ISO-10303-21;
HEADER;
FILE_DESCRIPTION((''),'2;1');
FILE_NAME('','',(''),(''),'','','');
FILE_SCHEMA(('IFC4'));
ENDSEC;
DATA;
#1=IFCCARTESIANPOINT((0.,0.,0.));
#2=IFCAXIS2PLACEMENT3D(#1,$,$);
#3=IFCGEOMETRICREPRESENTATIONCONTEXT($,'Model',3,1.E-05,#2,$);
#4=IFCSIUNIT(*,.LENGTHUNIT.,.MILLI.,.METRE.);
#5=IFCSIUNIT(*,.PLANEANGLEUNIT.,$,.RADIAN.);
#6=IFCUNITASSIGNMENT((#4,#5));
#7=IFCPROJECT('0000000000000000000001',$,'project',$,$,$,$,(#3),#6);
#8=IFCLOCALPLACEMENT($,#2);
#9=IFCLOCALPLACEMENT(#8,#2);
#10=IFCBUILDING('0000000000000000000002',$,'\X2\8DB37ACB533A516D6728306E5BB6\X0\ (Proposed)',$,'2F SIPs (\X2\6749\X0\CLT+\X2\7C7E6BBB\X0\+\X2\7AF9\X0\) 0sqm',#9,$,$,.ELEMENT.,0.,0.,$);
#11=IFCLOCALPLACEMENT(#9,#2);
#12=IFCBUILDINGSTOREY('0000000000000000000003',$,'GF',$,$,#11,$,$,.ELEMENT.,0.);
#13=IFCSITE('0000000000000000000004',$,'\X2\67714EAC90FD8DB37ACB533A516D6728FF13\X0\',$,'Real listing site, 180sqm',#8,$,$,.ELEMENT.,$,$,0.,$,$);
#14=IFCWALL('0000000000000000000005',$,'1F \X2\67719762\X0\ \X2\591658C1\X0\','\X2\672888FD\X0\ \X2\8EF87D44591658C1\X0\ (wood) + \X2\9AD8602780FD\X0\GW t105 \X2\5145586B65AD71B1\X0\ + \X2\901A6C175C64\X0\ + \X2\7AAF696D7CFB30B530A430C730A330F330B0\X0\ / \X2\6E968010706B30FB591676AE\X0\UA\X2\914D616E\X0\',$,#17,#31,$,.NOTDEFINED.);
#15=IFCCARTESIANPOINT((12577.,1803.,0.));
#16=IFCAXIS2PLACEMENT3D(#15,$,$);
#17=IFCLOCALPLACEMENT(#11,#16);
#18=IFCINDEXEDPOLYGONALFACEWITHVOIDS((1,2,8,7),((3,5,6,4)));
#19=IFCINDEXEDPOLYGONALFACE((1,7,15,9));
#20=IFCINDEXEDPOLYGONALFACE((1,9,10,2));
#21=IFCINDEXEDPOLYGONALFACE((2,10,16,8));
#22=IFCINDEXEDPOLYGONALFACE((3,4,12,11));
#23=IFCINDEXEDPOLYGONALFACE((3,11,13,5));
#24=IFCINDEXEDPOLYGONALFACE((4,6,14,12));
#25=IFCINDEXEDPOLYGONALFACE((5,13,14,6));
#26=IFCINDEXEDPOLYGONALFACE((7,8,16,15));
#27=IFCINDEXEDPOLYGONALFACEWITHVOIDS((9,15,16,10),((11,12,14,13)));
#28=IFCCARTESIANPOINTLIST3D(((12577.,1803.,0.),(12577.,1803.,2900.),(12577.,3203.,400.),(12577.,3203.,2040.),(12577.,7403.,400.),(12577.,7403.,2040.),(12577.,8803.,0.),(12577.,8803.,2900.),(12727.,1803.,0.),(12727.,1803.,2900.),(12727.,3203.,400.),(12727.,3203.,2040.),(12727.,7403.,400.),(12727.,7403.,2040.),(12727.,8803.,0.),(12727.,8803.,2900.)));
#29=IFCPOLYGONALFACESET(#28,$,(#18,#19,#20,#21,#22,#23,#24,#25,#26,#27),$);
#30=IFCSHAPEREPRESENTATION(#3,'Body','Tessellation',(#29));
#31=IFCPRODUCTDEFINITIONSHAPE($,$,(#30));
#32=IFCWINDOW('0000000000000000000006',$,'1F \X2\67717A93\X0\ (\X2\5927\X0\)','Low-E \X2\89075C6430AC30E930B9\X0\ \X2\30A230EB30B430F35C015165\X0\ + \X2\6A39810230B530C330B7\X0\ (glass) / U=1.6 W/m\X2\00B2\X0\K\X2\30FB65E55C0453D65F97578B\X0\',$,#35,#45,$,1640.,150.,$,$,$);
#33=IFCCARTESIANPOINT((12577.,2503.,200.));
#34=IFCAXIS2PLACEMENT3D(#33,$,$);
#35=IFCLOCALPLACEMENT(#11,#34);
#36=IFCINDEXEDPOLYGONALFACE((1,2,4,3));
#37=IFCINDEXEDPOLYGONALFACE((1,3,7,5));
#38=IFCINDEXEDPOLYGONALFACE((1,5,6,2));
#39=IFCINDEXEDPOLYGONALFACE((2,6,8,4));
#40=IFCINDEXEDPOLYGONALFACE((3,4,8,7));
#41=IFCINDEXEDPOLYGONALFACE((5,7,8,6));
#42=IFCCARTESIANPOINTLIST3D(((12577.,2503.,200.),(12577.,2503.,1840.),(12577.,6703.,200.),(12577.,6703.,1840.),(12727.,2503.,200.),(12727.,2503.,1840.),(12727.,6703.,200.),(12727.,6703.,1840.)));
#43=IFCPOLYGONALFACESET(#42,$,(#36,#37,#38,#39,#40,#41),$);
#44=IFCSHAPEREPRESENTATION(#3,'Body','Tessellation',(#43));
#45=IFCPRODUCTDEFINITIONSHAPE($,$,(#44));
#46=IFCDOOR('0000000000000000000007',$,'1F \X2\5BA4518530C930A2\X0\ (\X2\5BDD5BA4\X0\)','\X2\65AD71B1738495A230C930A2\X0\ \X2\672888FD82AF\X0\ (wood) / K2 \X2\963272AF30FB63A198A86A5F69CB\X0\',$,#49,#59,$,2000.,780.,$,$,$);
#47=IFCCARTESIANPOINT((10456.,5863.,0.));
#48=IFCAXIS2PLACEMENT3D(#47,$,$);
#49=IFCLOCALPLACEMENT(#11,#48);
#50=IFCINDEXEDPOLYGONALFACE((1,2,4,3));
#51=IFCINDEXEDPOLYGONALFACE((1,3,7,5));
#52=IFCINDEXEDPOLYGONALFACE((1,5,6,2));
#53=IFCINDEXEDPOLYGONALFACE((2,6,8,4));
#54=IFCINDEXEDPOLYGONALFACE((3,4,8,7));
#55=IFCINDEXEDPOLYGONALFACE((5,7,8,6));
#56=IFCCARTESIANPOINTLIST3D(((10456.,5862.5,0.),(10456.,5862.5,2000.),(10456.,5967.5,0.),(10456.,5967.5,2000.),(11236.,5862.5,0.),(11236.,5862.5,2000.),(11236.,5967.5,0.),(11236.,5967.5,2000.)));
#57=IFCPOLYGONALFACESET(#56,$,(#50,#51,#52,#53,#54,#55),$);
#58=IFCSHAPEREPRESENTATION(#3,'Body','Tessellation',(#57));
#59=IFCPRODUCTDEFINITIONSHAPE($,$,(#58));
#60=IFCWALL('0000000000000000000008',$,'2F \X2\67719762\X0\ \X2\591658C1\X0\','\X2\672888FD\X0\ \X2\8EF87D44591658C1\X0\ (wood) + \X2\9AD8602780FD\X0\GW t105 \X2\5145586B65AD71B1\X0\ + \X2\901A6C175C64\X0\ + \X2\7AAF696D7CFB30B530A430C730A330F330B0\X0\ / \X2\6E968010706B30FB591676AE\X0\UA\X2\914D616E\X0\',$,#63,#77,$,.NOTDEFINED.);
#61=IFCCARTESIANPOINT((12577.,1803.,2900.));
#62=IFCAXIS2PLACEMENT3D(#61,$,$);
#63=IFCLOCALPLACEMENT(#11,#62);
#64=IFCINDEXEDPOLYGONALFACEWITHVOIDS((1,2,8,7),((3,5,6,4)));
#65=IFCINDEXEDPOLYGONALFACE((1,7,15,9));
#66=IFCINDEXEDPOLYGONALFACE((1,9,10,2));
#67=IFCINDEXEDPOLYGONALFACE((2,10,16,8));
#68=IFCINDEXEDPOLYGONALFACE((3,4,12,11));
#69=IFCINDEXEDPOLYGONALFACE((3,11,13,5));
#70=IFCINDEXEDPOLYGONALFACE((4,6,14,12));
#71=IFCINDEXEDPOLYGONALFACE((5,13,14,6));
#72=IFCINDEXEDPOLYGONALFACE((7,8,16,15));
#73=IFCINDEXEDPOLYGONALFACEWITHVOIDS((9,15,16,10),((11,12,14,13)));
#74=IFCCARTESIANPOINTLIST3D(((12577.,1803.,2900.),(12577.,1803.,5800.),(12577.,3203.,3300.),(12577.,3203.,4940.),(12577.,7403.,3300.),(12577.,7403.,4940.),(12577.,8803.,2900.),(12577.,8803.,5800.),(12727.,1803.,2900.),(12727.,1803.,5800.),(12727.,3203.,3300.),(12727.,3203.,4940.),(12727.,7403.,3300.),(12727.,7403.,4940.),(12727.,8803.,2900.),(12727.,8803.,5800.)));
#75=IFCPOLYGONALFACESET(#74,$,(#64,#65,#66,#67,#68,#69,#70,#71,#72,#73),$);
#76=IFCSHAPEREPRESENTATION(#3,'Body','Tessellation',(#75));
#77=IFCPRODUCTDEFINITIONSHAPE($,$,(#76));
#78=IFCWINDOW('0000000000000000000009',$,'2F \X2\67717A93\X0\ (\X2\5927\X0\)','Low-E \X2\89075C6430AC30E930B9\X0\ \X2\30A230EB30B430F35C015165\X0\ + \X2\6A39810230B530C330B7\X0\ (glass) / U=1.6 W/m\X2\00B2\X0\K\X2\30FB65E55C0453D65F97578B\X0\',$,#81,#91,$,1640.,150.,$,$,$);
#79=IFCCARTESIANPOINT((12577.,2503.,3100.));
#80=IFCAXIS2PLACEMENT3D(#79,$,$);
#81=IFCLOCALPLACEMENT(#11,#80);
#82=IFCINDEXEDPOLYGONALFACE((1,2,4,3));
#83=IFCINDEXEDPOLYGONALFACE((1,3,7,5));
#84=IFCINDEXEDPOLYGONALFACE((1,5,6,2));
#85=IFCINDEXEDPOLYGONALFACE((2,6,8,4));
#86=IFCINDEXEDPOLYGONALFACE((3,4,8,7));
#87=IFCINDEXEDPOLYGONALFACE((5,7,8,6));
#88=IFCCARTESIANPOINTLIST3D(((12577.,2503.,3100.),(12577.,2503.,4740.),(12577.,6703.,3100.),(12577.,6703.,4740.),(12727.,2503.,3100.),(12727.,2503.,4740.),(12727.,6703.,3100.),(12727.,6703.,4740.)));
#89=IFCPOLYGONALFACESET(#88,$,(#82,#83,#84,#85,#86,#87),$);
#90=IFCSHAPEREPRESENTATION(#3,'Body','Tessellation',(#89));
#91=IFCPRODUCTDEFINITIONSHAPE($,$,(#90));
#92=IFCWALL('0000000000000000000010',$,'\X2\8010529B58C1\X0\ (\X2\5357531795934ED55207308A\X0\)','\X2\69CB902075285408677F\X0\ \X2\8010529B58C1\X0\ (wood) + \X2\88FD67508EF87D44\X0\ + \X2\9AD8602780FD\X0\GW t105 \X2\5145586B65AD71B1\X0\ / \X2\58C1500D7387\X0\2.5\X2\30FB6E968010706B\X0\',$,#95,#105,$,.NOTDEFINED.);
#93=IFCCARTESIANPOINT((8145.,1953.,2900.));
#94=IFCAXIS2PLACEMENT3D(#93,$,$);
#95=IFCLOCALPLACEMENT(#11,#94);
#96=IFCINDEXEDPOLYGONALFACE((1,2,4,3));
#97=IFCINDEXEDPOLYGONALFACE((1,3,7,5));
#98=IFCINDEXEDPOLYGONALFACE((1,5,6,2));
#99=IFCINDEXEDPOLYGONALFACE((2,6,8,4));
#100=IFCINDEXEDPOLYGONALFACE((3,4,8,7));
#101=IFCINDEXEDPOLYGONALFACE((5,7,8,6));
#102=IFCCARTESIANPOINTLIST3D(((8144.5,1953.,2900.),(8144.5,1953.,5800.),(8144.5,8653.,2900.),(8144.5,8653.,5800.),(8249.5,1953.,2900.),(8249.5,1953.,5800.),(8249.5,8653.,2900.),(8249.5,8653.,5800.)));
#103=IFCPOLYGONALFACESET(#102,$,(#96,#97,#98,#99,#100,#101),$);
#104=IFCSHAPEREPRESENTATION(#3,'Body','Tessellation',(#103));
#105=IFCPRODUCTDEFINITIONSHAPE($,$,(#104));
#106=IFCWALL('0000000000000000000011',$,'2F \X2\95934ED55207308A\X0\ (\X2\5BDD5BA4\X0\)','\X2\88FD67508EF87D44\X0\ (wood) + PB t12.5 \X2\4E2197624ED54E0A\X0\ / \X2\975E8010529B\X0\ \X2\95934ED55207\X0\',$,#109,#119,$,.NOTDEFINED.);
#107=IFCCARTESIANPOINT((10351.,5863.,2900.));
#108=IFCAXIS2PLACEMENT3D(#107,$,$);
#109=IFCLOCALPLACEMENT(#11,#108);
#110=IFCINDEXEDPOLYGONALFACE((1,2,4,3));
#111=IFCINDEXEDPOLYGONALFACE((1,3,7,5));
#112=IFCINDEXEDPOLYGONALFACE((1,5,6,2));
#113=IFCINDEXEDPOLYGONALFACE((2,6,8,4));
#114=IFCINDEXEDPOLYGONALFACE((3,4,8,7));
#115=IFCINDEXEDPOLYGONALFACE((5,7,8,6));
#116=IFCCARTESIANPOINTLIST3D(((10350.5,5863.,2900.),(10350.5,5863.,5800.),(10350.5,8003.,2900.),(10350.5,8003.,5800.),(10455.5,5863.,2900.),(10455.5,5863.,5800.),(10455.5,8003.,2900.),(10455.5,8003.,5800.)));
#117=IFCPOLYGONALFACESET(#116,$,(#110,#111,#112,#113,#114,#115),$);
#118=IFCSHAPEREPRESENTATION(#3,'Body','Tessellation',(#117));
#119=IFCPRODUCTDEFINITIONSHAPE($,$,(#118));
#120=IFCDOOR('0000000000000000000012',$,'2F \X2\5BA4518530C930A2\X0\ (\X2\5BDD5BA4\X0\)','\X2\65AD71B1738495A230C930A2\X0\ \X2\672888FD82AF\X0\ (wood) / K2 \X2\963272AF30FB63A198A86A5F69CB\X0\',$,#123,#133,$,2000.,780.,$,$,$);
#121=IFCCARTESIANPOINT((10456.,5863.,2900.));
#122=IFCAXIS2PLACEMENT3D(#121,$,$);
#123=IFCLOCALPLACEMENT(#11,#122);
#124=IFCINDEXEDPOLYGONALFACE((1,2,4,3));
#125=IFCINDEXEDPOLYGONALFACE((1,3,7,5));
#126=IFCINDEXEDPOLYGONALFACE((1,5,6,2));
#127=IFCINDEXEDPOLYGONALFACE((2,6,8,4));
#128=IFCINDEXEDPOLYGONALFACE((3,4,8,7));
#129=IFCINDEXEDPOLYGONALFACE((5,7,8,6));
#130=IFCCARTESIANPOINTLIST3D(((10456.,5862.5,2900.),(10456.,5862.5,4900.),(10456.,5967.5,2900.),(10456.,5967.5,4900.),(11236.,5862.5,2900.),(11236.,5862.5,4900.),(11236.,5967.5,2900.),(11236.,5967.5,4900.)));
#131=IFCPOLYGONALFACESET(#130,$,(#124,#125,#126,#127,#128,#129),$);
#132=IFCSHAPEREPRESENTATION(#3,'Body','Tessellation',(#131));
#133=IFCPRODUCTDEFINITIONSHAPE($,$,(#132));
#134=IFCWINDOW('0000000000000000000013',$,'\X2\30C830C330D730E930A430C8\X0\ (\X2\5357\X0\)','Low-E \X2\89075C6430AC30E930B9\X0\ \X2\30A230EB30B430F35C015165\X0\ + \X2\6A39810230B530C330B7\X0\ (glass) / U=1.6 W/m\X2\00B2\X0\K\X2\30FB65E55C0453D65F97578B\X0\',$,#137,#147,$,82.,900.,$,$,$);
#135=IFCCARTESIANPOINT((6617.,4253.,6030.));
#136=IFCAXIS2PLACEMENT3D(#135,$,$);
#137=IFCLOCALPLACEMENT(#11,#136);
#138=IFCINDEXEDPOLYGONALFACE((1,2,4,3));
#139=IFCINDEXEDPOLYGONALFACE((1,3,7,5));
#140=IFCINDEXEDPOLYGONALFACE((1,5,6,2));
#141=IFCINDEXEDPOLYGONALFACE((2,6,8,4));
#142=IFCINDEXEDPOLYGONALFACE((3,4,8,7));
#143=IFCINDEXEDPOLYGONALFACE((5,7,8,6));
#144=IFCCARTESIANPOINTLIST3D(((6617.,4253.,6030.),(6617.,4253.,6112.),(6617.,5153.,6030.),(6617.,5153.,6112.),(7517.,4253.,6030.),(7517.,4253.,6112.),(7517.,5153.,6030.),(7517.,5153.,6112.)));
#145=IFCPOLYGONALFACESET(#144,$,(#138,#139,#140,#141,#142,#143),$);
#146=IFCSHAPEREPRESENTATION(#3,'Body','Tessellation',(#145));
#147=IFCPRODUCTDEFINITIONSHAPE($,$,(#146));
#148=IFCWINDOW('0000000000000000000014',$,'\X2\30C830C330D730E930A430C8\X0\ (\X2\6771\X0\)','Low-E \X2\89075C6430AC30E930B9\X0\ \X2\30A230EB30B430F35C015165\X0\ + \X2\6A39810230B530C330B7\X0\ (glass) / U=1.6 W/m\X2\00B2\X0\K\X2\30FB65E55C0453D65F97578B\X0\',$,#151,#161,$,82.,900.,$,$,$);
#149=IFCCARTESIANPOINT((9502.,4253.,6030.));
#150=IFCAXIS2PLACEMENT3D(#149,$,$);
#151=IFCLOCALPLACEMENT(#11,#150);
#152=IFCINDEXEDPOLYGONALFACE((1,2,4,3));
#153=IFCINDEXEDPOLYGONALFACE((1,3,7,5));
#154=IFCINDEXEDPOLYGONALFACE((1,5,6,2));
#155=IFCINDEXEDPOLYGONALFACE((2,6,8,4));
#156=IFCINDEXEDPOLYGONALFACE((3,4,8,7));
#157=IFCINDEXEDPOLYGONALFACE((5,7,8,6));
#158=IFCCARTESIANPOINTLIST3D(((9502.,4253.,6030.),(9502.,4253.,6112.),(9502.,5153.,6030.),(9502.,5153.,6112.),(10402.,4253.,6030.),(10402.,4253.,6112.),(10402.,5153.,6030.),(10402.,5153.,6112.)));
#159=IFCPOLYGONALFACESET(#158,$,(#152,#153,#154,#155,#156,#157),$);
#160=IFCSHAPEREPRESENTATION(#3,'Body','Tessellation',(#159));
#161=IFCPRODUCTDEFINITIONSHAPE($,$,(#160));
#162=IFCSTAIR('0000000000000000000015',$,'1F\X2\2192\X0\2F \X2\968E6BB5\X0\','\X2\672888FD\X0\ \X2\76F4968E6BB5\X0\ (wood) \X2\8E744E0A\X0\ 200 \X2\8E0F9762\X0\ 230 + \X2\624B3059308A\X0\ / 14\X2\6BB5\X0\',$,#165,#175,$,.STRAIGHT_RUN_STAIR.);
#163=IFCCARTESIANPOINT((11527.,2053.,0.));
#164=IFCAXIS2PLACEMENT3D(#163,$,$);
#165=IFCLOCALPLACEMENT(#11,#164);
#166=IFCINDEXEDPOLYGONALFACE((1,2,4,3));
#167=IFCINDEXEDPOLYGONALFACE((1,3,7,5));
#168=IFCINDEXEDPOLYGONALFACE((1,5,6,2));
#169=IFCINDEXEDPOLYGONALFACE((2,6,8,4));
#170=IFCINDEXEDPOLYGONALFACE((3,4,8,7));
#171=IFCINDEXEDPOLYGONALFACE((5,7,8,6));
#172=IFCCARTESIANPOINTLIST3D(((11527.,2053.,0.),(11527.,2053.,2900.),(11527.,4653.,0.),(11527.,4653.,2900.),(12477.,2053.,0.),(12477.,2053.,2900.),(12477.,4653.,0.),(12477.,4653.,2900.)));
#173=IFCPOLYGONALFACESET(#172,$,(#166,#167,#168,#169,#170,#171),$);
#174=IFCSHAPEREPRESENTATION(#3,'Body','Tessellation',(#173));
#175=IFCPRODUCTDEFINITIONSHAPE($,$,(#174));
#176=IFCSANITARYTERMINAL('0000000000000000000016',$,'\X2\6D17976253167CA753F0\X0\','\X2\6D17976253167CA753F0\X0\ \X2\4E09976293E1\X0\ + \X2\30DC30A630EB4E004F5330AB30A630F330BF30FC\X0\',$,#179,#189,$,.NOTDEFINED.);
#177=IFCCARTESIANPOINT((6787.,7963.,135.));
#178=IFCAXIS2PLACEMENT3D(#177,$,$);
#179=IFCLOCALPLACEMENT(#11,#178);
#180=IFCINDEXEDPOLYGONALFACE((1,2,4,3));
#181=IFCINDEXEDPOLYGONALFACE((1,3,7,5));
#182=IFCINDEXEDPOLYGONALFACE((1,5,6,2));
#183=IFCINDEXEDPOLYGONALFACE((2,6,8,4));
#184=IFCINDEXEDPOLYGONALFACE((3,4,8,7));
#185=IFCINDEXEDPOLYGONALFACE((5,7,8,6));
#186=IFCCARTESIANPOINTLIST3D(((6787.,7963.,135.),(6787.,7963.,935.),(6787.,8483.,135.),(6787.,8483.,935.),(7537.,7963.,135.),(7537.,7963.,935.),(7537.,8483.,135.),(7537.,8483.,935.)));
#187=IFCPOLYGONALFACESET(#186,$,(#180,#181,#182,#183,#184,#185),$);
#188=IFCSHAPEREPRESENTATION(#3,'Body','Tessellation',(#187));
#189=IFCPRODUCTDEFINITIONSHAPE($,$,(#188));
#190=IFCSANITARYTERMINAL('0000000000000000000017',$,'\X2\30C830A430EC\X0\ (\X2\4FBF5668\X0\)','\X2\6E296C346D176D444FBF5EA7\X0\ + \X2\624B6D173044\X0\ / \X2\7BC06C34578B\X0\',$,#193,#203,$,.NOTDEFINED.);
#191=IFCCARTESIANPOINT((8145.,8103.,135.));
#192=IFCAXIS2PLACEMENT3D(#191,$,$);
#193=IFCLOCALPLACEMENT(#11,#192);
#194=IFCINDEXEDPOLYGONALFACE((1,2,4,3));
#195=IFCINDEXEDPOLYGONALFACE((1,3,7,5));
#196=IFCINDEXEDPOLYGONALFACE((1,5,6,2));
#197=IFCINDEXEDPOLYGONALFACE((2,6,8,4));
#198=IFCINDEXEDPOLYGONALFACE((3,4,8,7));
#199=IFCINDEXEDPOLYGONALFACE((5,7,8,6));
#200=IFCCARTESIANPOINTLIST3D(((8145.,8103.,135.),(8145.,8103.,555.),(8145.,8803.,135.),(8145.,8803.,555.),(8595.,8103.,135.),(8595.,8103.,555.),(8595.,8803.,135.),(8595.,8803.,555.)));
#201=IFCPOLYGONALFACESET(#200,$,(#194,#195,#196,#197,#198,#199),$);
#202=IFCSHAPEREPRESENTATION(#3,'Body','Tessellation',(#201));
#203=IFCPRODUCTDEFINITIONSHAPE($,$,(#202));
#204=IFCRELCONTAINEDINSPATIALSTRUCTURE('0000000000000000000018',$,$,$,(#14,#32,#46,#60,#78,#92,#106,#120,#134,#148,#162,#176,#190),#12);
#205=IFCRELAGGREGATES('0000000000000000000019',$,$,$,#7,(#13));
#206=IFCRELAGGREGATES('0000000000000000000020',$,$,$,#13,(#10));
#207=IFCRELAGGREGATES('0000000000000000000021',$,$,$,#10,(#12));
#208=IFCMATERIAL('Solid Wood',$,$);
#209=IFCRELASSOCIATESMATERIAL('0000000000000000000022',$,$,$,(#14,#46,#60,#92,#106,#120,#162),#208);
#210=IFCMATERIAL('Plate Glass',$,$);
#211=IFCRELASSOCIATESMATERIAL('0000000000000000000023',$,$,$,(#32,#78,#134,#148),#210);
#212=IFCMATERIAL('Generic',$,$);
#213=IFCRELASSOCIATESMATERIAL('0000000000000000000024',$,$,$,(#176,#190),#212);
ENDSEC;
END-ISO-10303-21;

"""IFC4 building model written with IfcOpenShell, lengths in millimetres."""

from ifc_helpers import new_model, si_unit, frame, frame_2d, origin, place, context, project, spatial, rectangle, extrude, material, element, fill, save


model = new_model("IFC4")

# Units and contexts
model_context = context("Model", 3, precision=1e-05, world=origin())
ifc_project = project(units=[si_unit("LENGTHUNIT", "METRE", prefix="MILLI"), si_unit("PLANEANGLEUNIT", "RADIAN")], contexts=[model_context])

# Site, building, storey
site_placement = place(None, origin())
site = spatial("IfcSite", under=ifc_project, at=site_placement, Name="東京都足立区六木３", ObjectType="Real listing site, 180sqm", CompositionType="ELEMENT", RefElevation=0.0)
building_placement = place(site_placement, origin())
building = spatial("IfcBuilding", under=site, at=building_placement, Name="足立区六木の家 (Proposed)", ObjectType="2F SIPs (杉CLT+籾殻+竹) 0sqm", CompositionType="ELEMENT", ElevationOfRefHeight=0.0, ElevationOfTerrain=0.0)
storey_placement = place(building_placement, origin())
storey = spatial("IfcBuildingStorey", under=building, at=storey_placement, Name="GF", CompositionType="ELEMENT", Elevation=0.0)

# Wall, opening, window
ifc_material_1 = material(Name="Solid Wood")
wall_1_placement = place(storey_placement, frame((12577.0, 1803.0, 0.0)))
wall_1 = element("IfcWall", 1, at=wall_1_placement, inside=storey, material=ifc_material_1, Name="1F 東面 外壁", Description="木製 軸組外壁 (wood) + 高性能GW t105 充填断熱 + 通気層 + 窯業系サイディング / 準耐火・外皮UA配慮", PredefinedType="NOTDEFINED", context=model_context, shape_type="SweptSolid", body=[
    extrude(rectangle(XDim=150.0, YDim=7000.0, at=frame_2d((75.0, 3500.0))), frame((12577.0, 1803.0, 0.0)), (0.0, 0.0, 1.0), 2900.0),
])
opening_1_placement = place(storey_placement, frame((12577.0, 2503.0, 200.0)))
opening_1 = element("IfcOpeningElement", 2, at=opening_1_placement, cuts=wall_1, PredefinedType="NOTDEFINED", context=model_context, shape_type="SweptSolid", body=[
    extrude(rectangle(XDim=150.0, YDim=4200.0, at=frame_2d((75.0, 2100.0))), frame((12577.0, 2503.0, 200.0)), (0.0, 0.0, 1.0), 1640.0),
])
ifc_material_2 = material(Name="Plate Glass")
window_1_placement = place(storey_placement, frame((12577.0, 2503.0, 200.0)))
window_1 = element("IfcWindow", 3, at=window_1_placement, inside=storey, material=ifc_material_2, Name="1F 東窓 (大)", Description="Low-E 複層ガラス アルゴン封入 + 樹脂サッシ (glass) / U=1.6 W/m²K・日射取得型", OverallHeight=1640.0, OverallWidth=150.0, context=model_context, shape_type="SweptSolid", body=[
    extrude(rectangle(XDim=150.0, YDim=4200.0, at=frame_2d((75.0, 2100.0))), frame((12577.0, 2503.0, 200.0)), (0.0, 0.0, 1.0), 1640.0),
])
fill(opening_1, window_1)

# Door
door_1_placement = place(storey_placement, frame((10456.0, 5863.0, 0.0)))
element("IfcDoor", 4, at=door_1_placement, inside=storey, material=ifc_material_1, Name="1F 室内ドア (寝室)", Description="断熱玄関ドア 木製芯 (wood) / K2 防犯・採風機構", OverallHeight=2000.0, OverallWidth=780.0, context=model_context, shape_type="SweptSolid", body=[
    extrude(rectangle(XDim=780.0, YDim=105.0, at=frame_2d((390.0, 52.0))), frame((10456.0, 5863.0, 0.0)), (0.0, 0.0, 1.0), 2000.0),
])

# Wall, opening, window
wall_2_placement = place(storey_placement, frame((12577.0, 1803.0, 2900.0)))
wall_2 = element("IfcWall", 5, at=wall_2_placement, inside=storey, material=ifc_material_1, Name="2F 東面 外壁", Description="木製 軸組外壁 (wood) + 高性能GW t105 充填断熱 + 通気層 + 窯業系サイディング / 準耐火・外皮UA配慮", PredefinedType="NOTDEFINED", context=model_context, shape_type="SweptSolid", body=[
    extrude(rectangle(XDim=150.0, YDim=7000.0, at=frame_2d((75.0, 3500.0))), frame((12577.0, 1803.0, 2900.0)), (0.0, 0.0, 1.0), 2900.0),
])
opening_2_placement = place(storey_placement, frame((12577.0, 2503.0, 3100.0)))
opening_2 = element("IfcOpeningElement", 6, at=opening_2_placement, cuts=wall_2, PredefinedType="NOTDEFINED", context=model_context, shape_type="SweptSolid", body=[
    extrude(rectangle(XDim=150.0, YDim=4200.0, at=frame_2d((75.0, 2100.0))), frame((12577.0, 2503.0, 3100.0)), (0.0, 0.0, 1.0), 1640.0),
])
window_2_placement = place(storey_placement, frame((12577.0, 2503.0, 3100.0)))
window_2 = element("IfcWindow", 7, at=window_2_placement, inside=storey, material=ifc_material_2, Name="2F 東窓 (大)", Description="Low-E 複層ガラス アルゴン封入 + 樹脂サッシ (glass) / U=1.6 W/m²K・日射取得型", OverallHeight=1640.0, OverallWidth=150.0, context=model_context, shape_type="SweptSolid", body=[
    extrude(rectangle(XDim=150.0, YDim=4200.0, at=frame_2d((75.0, 2100.0))), frame((12577.0, 2503.0, 3100.0)), (0.0, 0.0, 1.0), 1640.0),
])
fill(opening_2, window_2)

# Walls
wall_3_placement = place(storey_placement, frame((8145.0, 1953.0, 2900.0)))
element("IfcWall", 8, at=wall_3_placement, inside=storey, material=ifc_material_1, Name="耐力壁 (南北間仕切り)", Description="構造用合板 耐力壁 (wood) + 製材軸組 + 高性能GW t105 充填断熱 / 壁倍率2.5・準耐火", PredefinedType="NOTDEFINED", context=model_context, shape_type="SweptSolid", body=[
    extrude(rectangle(XDim=105.0, YDim=6700.0, at=frame_2d((52.0, 3350.0))), frame((8145.0, 1953.0, 2900.0)), (0.0, 0.0, 1.0), 2900.0),
])
wall_4_placement = place(storey_placement, frame((10351.0, 5863.0, 2900.0)))
element("IfcWall", 9, at=wall_4_placement, inside=storey, material=ifc_material_1, Name="2F 間仕切り (寝室)", Description="製材軸組 (wood) + PB t12.5 両面仕上 / 非耐力 間仕切", PredefinedType="NOTDEFINED", context=model_context, shape_type="SweptSolid", body=[
    extrude(rectangle(XDim=105.0, YDim=2140.0, at=frame_2d((52.0, 1070.0))), frame((10351.0, 5863.0, 2900.0)), (0.0, 0.0, 1.0), 2900.0),
])

# Door
door_2_placement = place(storey_placement, frame((10456.0, 5863.0, 2900.0)))
element("IfcDoor", 10, at=door_2_placement, inside=storey, material=ifc_material_1, Name="2F 室内ドア (寝室)", Description="断熱玄関ドア 木製芯 (wood) / K2 防犯・採風機構", OverallHeight=2000.0, OverallWidth=780.0, context=model_context, shape_type="SweptSolid", body=[
    extrude(rectangle(XDim=780.0, YDim=105.0, at=frame_2d((390.0, 52.0))), frame((10456.0, 5863.0, 2900.0)), (0.0, 0.0, 1.0), 2000.0),
])

# Windows
window_3_placement = place(storey_placement, frame((6617.0, 4253.0, 6030.0)))
element("IfcWindow", 11, at=window_3_placement, inside=storey, material=ifc_material_2, Name="トップライト (南)", Description="Low-E 複層ガラス アルゴン封入 + 樹脂サッシ (glass) / U=1.6 W/m²K・日射取得型", OverallHeight=82.0, OverallWidth=900.0, context=model_context, shape_type="SweptSolid", body=[
    extrude(rectangle(XDim=900.0, YDim=900.0, at=frame_2d((450.0, 450.0))), frame((6617.0, 4253.0, 6030.0)), (0.0, 0.0, 1.0), 82.0),
])
window_4_placement = place(storey_placement, frame((9502.0, 4253.0, 6030.0)))
element("IfcWindow", 12, at=window_4_placement, inside=storey, material=ifc_material_2, Name="トップライト (東)", Description="Low-E 複層ガラス アルゴン封入 + 樹脂サッシ (glass) / U=1.6 W/m²K・日射取得型", OverallHeight=82.0, OverallWidth=900.0, context=model_context, shape_type="SweptSolid", body=[
    extrude(rectangle(XDim=900.0, YDim=900.0, at=frame_2d((450.0, 450.0))), frame((9502.0, 4253.0, 6030.0)), (0.0, 0.0, 1.0), 82.0),
])

# Stair
stair_placement = place(storey_placement, frame((11527.0, 2053.0, 0.0)))
element("IfcStair", 13, at=stair_placement, inside=storey, material=ifc_material_1, Name="1F→2F 階段", Description="木製 直階段 (wood) 蹴上 200 踏面 230 + 手すり / 14段", PredefinedType="STRAIGHT_RUN_STAIR", context=model_context, shape_type="SweptSolid", body=[
    extrude(rectangle(XDim=950.0, YDim=2600.0, at=frame_2d((475.0, 1300.0))), frame((11527.0, 2053.0, 0.0)), (0.0, 0.0, 1.0), 2900.0),
])

# Sanitary terminals
ifc_material_3 = material(Name="Generic")
sanitary_terminal_1_placement = place(storey_placement, frame((6787.0, 7963.0, 135.0)))
element("IfcSanitaryTerminal", 14, at=sanitary_terminal_1_placement, inside=storey, material=ifc_material_3, Name="洗面化粧台", Description="洗面化粧台 三面鏡 + ボウル一体カウンター", PredefinedType="NOTDEFINED", context=model_context, shape_type="SweptSolid", body=[
    extrude(rectangle(XDim=750.0, YDim=520.0, at=frame_2d((375.0, 260.0))), frame((6787.0, 7963.0, 135.0)), (0.0, 0.0, 1.0), 800.0),
])
sanitary_terminal_2_placement = place(storey_placement, frame((8145.0, 8103.0, 135.0)))
element("IfcSanitaryTerminal", 15, at=sanitary_terminal_2_placement, inside=storey, material=ifc_material_3, Name="トイレ (便器)", Description="温水洗浄便座 + 手洗い / 節水型", PredefinedType="NOTDEFINED", context=model_context, shape_type="SweptSolid", body=[
    extrude(rectangle(XDim=450.0, YDim=700.0, at=frame_2d((225.0, 350.0))), frame((8145.0, 8103.0, 135.0)), (0.0, 0.0, 1.0), 420.0),
])

save(model, "model.ifc")
